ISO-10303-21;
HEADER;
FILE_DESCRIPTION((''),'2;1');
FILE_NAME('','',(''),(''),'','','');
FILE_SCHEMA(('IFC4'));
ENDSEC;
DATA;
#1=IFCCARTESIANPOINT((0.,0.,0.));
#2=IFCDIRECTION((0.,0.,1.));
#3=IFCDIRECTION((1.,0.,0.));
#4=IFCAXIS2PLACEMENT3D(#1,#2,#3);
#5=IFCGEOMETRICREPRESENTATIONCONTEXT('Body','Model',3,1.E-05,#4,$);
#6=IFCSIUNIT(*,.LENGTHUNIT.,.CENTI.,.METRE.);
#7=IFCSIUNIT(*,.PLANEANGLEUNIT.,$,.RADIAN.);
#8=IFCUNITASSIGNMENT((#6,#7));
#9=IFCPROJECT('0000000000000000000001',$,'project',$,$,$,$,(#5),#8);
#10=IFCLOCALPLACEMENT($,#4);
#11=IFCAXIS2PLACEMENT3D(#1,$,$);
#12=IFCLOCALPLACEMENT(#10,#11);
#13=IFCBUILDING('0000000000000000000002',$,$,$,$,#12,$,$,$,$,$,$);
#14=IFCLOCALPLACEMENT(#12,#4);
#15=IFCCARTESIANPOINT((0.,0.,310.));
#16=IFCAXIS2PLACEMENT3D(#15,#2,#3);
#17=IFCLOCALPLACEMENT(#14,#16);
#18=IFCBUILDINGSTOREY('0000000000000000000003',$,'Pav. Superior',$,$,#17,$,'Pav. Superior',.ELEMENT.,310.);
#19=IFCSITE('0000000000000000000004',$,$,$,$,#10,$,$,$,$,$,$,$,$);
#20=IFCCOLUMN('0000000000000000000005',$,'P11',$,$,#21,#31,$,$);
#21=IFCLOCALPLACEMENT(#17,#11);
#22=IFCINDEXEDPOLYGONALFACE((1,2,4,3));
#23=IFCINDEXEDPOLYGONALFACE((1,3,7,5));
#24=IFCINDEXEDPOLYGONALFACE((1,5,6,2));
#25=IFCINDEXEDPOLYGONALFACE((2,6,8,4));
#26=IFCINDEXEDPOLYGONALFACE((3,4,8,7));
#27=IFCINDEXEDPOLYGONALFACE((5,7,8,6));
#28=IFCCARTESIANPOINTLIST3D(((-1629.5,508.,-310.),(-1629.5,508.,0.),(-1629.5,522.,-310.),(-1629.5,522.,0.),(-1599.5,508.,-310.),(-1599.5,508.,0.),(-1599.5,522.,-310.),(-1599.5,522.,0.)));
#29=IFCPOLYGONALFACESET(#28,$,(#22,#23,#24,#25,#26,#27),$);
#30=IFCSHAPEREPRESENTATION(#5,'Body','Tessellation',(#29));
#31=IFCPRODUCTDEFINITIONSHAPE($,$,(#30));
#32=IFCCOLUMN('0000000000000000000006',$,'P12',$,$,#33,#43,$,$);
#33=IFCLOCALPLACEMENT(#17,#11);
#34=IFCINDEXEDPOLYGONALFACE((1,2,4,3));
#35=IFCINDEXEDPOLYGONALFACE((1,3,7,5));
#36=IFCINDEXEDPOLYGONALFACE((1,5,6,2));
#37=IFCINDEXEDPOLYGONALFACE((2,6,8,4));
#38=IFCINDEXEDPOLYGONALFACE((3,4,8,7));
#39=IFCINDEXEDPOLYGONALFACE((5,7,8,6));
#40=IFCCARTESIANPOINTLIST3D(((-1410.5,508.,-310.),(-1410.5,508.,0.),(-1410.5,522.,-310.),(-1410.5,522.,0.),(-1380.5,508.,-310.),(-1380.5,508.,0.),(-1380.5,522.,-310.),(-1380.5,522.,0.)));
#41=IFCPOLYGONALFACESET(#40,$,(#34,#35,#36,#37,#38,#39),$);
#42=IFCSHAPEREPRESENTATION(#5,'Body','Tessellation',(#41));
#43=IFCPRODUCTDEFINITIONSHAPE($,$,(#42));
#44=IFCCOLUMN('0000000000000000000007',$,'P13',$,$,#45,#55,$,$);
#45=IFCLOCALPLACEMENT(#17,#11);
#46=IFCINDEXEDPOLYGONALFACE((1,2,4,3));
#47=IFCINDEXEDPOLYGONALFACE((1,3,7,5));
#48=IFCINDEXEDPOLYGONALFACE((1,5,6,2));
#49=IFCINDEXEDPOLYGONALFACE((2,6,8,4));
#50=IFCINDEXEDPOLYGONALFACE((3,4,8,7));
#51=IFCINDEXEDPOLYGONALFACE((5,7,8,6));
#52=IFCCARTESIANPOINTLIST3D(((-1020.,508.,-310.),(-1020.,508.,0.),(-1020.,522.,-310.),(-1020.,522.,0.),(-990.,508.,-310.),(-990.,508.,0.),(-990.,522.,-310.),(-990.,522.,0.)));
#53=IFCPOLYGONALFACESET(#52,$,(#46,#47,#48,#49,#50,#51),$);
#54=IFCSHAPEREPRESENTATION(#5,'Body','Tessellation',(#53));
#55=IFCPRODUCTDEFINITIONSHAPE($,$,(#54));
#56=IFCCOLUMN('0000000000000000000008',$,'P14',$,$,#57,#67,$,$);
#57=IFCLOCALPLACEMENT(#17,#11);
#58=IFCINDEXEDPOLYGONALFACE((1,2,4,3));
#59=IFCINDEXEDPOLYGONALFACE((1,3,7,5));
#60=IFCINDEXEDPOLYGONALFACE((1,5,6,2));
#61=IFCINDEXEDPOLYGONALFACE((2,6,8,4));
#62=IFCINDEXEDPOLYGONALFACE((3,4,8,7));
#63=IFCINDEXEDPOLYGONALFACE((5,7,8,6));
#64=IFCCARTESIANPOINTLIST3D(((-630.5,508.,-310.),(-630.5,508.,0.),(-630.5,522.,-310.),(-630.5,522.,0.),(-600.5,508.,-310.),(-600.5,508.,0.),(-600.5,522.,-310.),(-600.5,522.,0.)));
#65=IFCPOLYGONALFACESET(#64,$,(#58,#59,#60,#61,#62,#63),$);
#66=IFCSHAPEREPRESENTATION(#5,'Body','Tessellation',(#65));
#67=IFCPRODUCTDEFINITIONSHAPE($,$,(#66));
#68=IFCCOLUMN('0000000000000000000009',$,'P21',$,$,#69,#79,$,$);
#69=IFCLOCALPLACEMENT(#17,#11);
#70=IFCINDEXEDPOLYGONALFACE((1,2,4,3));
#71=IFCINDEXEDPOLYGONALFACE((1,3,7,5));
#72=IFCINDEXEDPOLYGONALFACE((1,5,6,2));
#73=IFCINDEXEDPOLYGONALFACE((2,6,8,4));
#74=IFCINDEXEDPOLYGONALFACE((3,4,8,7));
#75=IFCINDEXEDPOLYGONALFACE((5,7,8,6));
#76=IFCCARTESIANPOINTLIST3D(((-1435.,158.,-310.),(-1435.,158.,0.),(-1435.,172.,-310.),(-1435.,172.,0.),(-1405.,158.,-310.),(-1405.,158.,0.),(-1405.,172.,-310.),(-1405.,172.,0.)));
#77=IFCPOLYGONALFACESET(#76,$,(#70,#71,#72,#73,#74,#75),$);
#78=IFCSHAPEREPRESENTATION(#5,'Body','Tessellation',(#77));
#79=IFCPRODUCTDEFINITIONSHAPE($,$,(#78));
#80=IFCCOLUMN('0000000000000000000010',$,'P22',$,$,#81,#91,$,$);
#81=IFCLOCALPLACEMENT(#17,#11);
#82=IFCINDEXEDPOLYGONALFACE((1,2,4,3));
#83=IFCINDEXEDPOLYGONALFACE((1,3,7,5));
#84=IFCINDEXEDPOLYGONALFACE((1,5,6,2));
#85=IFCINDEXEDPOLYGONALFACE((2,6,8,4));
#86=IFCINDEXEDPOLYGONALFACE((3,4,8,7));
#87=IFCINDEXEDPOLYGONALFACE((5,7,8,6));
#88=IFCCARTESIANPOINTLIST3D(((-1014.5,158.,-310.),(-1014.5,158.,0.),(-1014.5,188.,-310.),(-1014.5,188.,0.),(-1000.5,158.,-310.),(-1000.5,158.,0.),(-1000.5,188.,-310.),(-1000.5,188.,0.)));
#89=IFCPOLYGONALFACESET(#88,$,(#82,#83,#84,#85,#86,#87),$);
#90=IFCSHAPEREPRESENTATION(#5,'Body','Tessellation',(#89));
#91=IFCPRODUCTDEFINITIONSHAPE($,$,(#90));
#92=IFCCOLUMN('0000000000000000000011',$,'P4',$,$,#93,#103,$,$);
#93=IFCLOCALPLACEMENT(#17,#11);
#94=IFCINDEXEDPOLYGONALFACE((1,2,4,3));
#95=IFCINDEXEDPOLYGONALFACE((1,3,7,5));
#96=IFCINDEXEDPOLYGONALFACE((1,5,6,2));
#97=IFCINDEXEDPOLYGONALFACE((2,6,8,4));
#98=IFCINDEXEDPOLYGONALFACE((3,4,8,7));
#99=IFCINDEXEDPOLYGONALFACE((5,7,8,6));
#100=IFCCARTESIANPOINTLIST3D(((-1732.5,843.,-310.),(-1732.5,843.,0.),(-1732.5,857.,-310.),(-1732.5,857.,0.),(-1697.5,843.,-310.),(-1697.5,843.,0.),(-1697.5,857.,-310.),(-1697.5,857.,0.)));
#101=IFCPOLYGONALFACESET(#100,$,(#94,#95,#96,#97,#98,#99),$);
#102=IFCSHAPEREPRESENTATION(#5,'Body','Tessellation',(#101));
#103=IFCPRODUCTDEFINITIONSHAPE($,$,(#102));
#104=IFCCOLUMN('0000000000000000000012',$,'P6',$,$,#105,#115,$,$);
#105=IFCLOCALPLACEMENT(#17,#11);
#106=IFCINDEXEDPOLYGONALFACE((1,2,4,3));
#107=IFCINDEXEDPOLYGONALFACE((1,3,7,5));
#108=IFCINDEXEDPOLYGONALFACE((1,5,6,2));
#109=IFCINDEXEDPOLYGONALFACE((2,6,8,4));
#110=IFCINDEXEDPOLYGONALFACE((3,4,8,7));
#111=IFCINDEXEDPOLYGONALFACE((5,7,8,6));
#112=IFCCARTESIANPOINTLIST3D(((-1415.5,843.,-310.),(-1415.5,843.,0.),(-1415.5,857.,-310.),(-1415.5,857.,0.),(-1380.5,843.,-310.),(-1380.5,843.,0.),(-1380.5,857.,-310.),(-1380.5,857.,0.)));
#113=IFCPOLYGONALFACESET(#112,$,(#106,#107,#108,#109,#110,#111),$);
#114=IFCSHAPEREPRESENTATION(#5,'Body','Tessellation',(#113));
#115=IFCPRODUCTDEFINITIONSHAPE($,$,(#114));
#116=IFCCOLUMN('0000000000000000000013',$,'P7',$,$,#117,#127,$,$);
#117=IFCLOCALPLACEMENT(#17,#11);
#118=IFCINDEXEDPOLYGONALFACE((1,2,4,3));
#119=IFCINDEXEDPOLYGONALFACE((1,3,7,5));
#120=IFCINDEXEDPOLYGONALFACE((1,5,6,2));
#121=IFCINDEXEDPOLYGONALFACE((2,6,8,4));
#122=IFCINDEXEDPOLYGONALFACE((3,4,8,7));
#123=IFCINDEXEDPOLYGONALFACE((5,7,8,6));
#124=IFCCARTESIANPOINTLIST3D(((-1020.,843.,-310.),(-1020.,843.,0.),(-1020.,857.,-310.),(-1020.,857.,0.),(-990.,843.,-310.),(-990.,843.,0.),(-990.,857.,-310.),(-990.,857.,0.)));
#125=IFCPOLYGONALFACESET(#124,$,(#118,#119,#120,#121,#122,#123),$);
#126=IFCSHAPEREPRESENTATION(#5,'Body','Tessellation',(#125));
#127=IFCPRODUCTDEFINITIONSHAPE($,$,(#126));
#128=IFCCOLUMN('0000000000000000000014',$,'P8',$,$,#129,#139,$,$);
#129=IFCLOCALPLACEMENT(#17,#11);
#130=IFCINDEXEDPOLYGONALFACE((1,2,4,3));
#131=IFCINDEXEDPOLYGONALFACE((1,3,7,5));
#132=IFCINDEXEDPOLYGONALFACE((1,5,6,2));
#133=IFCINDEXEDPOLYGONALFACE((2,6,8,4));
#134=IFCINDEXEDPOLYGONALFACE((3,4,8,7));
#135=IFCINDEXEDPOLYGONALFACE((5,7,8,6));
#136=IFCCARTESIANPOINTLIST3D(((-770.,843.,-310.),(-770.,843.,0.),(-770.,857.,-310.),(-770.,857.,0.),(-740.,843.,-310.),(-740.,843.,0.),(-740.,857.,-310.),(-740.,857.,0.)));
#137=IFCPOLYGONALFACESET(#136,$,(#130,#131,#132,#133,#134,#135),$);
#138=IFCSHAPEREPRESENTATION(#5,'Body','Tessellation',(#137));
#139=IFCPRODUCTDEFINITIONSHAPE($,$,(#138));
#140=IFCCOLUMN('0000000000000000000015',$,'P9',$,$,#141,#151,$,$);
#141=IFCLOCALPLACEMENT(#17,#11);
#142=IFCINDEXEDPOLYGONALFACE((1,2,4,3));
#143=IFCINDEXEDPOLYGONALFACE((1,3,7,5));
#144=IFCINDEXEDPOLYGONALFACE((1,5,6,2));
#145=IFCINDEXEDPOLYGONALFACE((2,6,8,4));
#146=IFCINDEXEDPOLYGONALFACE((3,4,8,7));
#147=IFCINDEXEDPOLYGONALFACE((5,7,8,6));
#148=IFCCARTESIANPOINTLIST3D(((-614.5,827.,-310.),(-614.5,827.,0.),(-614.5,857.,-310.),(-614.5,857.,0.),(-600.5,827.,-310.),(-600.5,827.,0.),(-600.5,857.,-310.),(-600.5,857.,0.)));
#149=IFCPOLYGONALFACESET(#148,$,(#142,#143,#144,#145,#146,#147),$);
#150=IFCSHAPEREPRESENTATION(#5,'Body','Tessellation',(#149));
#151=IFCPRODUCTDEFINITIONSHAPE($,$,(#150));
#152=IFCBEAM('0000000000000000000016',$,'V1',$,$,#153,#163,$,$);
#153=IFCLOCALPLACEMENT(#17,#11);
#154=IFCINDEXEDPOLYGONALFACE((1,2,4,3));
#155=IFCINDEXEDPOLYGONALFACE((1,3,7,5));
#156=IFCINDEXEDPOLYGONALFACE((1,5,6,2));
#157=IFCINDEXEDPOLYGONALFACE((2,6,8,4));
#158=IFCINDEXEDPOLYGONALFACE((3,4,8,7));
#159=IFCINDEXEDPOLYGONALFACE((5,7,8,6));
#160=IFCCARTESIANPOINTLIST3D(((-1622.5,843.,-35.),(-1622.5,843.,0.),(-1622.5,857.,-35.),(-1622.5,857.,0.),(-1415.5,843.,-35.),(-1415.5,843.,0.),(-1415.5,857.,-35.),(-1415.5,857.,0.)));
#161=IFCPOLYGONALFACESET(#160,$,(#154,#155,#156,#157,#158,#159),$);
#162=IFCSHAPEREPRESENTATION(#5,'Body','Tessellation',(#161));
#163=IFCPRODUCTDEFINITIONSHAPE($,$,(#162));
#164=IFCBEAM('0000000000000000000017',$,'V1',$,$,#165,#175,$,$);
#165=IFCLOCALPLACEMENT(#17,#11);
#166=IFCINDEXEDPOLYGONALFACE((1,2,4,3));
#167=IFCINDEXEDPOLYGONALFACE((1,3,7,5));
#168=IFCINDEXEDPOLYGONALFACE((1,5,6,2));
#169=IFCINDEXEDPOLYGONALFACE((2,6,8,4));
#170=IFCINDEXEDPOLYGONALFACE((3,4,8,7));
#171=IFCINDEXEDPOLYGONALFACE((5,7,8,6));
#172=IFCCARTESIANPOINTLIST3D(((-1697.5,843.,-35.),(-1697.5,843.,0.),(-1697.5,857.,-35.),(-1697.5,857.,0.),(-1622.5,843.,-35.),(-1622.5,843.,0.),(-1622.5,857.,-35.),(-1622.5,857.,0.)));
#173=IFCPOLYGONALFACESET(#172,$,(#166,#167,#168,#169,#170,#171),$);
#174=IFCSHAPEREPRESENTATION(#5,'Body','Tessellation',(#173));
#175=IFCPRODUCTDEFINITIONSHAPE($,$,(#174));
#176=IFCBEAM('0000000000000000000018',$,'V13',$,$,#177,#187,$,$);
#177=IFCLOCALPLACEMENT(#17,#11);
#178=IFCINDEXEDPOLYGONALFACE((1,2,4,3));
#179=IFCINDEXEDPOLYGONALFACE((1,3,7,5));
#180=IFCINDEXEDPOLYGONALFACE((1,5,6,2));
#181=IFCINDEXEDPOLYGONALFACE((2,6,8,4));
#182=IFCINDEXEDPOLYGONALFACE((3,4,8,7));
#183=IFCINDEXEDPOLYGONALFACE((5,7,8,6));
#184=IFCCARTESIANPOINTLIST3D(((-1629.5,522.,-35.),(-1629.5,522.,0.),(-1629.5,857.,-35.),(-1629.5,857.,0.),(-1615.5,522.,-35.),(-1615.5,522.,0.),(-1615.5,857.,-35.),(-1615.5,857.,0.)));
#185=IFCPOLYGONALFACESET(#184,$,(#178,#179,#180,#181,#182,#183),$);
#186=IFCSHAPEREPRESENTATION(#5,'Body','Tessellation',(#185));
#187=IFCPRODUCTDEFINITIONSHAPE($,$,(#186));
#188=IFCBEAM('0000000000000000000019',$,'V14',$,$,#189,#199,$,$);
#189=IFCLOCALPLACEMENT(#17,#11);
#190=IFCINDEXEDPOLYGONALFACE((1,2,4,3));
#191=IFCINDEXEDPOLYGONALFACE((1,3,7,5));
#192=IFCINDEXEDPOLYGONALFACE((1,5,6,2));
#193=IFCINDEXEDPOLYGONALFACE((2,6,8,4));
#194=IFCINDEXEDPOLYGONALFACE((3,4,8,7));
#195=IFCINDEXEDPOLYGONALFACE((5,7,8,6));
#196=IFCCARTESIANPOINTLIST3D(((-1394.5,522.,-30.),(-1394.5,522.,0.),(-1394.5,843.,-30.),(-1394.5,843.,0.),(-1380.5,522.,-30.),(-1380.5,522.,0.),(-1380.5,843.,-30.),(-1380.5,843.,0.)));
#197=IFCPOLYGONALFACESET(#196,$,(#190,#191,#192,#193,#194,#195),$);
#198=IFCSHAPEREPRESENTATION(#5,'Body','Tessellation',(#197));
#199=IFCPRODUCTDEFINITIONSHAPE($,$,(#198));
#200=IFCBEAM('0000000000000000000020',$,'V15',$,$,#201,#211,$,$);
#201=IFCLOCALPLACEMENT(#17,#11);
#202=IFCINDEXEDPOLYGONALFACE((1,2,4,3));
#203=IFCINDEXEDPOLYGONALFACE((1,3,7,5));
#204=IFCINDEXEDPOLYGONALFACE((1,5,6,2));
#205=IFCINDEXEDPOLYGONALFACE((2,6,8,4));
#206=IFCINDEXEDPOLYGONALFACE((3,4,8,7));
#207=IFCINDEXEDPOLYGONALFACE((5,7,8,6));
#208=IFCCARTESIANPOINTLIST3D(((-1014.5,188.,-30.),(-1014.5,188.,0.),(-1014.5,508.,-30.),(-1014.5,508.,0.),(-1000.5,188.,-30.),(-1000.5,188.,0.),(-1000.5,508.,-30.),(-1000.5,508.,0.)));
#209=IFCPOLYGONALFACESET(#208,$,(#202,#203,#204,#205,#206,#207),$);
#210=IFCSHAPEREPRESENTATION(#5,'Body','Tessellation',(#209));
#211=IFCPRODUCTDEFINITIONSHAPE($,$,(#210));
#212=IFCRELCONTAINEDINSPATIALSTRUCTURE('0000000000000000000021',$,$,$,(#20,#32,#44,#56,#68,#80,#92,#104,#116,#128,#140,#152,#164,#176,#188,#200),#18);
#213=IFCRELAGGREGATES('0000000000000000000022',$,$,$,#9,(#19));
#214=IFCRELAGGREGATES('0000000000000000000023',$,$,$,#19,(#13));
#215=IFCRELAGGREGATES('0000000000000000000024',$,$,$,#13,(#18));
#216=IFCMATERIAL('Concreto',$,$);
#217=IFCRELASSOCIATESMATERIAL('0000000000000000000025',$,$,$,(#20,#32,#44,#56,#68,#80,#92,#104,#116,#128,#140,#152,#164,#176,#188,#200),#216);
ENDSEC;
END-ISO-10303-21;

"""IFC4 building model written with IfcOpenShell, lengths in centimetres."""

from ifc_helpers import new_model, si_unit, frame, origin, origin_with_axes, origin_2d_with_axis, place, context, project, spatial, rectangle, extrude, material, element, save


model = new_model("IFC4")

# Units and contexts
model_context = context("Model", 3, precision=1e-05, world=origin_with_axes(), identifier="Body")
ifc_project = project(units=[si_unit("LENGTHUNIT", "METRE", prefix="CENTI"), si_unit("PLANEANGLEUNIT", "RADIAN")], contexts=[model_context])

# Site, building, storey
site_placement = place(None, origin_with_axes())
site = spatial("IfcSite", under=ifc_project, at=site_placement)
building_placement = place(site_placement, origin())
building = spatial("IfcBuilding", under=site, at=building_placement)
placement = place(building_placement, origin_with_axes())
storey_placement = place(placement, frame((0.0, 0.0, 310.0), z_axis=(0.0, 0.0, 1.0), x_axis=(1.0, 0.0, 0.0)))
storey = spatial("IfcBuildingStorey", under=building, at=storey_placement, Name="Pav. Superior", LongName="Pav. Superior", CompositionType="ELEMENT", Elevation=310.0)

# Columns
ifc_material = material(Name="Concreto")
for number, where, z_axis, x_axis, name in (
    (1, (-1614.5, 515.0, 0.0), (0.0, 0.0, 1.0), (1.0, 0.0, 0.0), "P11"),
    (2, (-1395.5, 515.0, 0.0), (0.0, 0.0, 1.0), (1.0, 0.0, 0.0), "P12"),
):
    element("IfcColumn", number, at=place(storey_placement, frame(where, z_axis=z_axis, x_axis=x_axis)), inside=storey, material=ifc_material, Name=name, context=model_context, shape_type="SolidModel", body=[
        extrude(rectangle(XDim=14.0, YDim=30.0, at=origin_2d_with_axis()), frame((0.0, 0.0, 0.0), z_axis=(0.0, 0.0, 1.0), x_axis=(0.0, 1.0, 0.0)), (0.0, 0.0, -1.0), 310.0),
    ])
for number, where, z_axis, x_axis, name in (
    (3, (-1005.0, 515.0, 0.0), (0.0, 0.0, 1.0), (1.0, 0.0, 0.0), "P13"),
    (4, (-615.5, 515.0, 0.0), (0.0, 0.0, 1.0), (1.0, 0.0, 0.0), "P14"),
    (5, (-1420.0, 165.0, 0.0), (0.0, 0.0, 1.0), (1.0, 0.0, 0.0), "P21"),
):
    element("IfcColumn", number, at=place(storey_placement, frame(where, z_axis=z_axis, x_axis=x_axis)), inside=storey, material=ifc_material, Name=name, context=model_context, shape_type="SolidModel", body=[
        extrude(rectangle(XDim=14.0, YDim=30.0, at=origin_2d_with_axis()), frame((0.0, 0.0, 0.0), z_axis=(0.0, 0.0, 1.0), x_axis=(0.0, -1.0, 0.0)), (0.0, 0.0, -1.0), 310.0),
    ])
column_1_placement = place(storey_placement, frame((-1007.5, 173.0, 0.0), z_axis=(0.0, 0.0, 1.0), x_axis=(1.0, 0.0, 0.0)))
element("IfcColumn", 6, at=column_1_placement, inside=storey, material=ifc_material, Name="P22", context=model_context, shape_type="SolidModel", body=[
    extrude(rectangle(XDim=14.0, YDim=30.0, at=origin_2d_with_axis()), origin_with_axes(), (0.0, 0.0, -1.0), 310.0),
])
for number, where, z_axis, x_axis, name in (
    (7, (-1715.0, 850.0, 0.0), (0.0, 0.0, 1.0), (1.0, 0.0, 0.0), "P4"),
    (8, (-1398.0, 850.0, 0.0), (0.0, 0.0, 1.0), (1.0, 0.0, 0.0), "P6"),
):
    element("IfcColumn", number, at=place(storey_placement, frame(where, z_axis=z_axis, x_axis=x_axis)), inside=storey, material=ifc_material, Name=name, context=model_context, shape_type="SolidModel", body=[
        extrude(rectangle(XDim=14.0, YDim=35.0, at=origin_2d_with_axis()), frame((0.0, 0.0, 0.0), z_axis=(0.0, 0.0, 1.0), x_axis=(0.0, 1.0, 0.0)), (0.0, 0.0, -1.0), 310.0),
    ])
for number, where, z_axis, x_axis, name in (
    (9, (-1005.0, 850.0, 0.0), (0.0, 0.0, 1.0), (1.0, 0.0, 0.0), "P7"),
    (10, (-755.0, 850.0, 0.0), (0.0, 0.0, 1.0), (1.0, 0.0, 0.0), "P8"),
):
    element("IfcColumn", number, at=place(storey_placement, frame(where, z_axis=z_axis, x_axis=x_axis)), inside=storey, material=ifc_material, Name=name, context=model_context, shape_type="SolidModel", body=[
        extrude(rectangle(XDim=14.0, YDim=30.0, at=origin_2d_with_axis()), frame((0.0, 0.0, 0.0), z_axis=(0.0, 0.0, 1.0), x_axis=(0.0, 1.0, 0.0)), (0.0, 0.0, -1.0), 310.0),
    ])
column_2_placement = place(storey_placement, frame((-607.5, 842.0, 0.0), z_axis=(0.0, 0.0, 1.0), x_axis=(1.0, 0.0, 0.0)))
element("IfcColumn", 11, at=column_2_placement, inside=storey, material=ifc_material, Name="P9", context=model_context, shape_type="SolidModel", body=[
    extrude(rectangle(XDim=14.0, YDim=30.0, at=origin_2d_with_axis()), frame((0.0, 0.0, 0.0), z_axis=(0.0, 0.0, 1.0), x_axis=(-1.0, 0.0, 0.0)), (0.0, 0.0, -1.0), 310.0),
])

# Beams
beam_1_placement = place(storey_placement, frame((-1519.0, 850.0, 0.0), z_axis=(0.0, 0.0, 1.0), x_axis=(1.0, 0.0, 0.0)))
element("IfcBeam", 12, at=beam_1_placement, inside=storey, material=ifc_material, Name="V1", context=model_context, shape_type="SolidModel", body=[
    extrude(rectangle(XDim=14.0, YDim=35.0, at=origin_2d_with_axis()), frame((-103.5, 0.0, -17.5), z_axis=(1.0, 0.0, 0.0), x_axis=(0.0, -1.0, 0.0)), (0.0, 0.0, 1.0), 207.0),
])
beam_2_placement = place(storey_placement, frame((-1660.0, 850.0, 0.0), z_axis=(0.0, 0.0, 1.0), x_axis=(1.0, 0.0, 0.0)))
element("IfcBeam", 13, at=beam_2_placement, inside=storey, material=ifc_material, Name="V1", context=model_context, shape_type="SolidModel", body=[
    extrude(rectangle(XDim=14.0, YDim=35.0, at=origin_2d_with_axis()), frame((-37.5, 0.0, -17.5), z_axis=(1.0, 0.0, 0.0), x_axis=(0.0, -1.0, 0.0)), (0.0, 0.0, 1.0), 75.0),
])
beam_3_placement = place(storey_placement, frame((-1622.5, 689.5, 0.0), z_axis=(0.0, 0.0, 1.0), x_axis=(1.0, 0.0, 0.0)))
element("IfcBeam", 14, at=beam_3_placement, inside=storey, material=ifc_material, Name="V13", context=model_context, shape_type="SolidModel", body=[
    extrude(rectangle(XDim=14.0, YDim=35.0, at=origin_2d_with_axis()), frame((0.0, -167.5, -17.5), z_axis=(0.0, 1.0, 0.0), x_axis=(-1.0, 0.0, 0.0)), (0.0, 0.0, 1.0), 335.0),
])
beam_4_placement = place(storey_placement, frame((-1387.5, 682.5, 0.0), z_axis=(0.0, 0.0, 1.0), x_axis=(1.0, 0.0, 0.0)))
element("IfcBeam", 15, at=beam_4_placement, inside=storey, material=ifc_material, Name="V14", context=model_context, shape_type="SolidModel", body=[
    extrude(rectangle(XDim=14.0, YDim=30.0, at=origin_2d_with_axis()), frame((0.0, -160.5, -15.0), z_axis=(0.0, 1.0, 0.0), x_axis=(-1.0, 0.0, 0.0)), (0.0, 0.0, 1.0), 321.0),
])
beam_5_placement = place(storey_placement, frame((-1007.5, 348.0, 0.0), z_axis=(0.0, 0.0, 1.0), x_axis=(1.0, 0.0, 0.0)))
element("IfcBeam", 16, at=beam_5_placement, inside=storey, material=ifc_material, Name="V15", context=model_context, shape_type="SolidModel", body=[
    extrude(rectangle(XDim=14.0, YDim=30.0, at=origin_2d_with_axis()), frame((0.0, -160.0, -15.0), z_axis=(0.0, 1.0, 0.0), x_axis=(-1.0, 0.0, 0.0)), (0.0, 0.0, 1.0), 320.0),
])

save(model, "model.ifc")
